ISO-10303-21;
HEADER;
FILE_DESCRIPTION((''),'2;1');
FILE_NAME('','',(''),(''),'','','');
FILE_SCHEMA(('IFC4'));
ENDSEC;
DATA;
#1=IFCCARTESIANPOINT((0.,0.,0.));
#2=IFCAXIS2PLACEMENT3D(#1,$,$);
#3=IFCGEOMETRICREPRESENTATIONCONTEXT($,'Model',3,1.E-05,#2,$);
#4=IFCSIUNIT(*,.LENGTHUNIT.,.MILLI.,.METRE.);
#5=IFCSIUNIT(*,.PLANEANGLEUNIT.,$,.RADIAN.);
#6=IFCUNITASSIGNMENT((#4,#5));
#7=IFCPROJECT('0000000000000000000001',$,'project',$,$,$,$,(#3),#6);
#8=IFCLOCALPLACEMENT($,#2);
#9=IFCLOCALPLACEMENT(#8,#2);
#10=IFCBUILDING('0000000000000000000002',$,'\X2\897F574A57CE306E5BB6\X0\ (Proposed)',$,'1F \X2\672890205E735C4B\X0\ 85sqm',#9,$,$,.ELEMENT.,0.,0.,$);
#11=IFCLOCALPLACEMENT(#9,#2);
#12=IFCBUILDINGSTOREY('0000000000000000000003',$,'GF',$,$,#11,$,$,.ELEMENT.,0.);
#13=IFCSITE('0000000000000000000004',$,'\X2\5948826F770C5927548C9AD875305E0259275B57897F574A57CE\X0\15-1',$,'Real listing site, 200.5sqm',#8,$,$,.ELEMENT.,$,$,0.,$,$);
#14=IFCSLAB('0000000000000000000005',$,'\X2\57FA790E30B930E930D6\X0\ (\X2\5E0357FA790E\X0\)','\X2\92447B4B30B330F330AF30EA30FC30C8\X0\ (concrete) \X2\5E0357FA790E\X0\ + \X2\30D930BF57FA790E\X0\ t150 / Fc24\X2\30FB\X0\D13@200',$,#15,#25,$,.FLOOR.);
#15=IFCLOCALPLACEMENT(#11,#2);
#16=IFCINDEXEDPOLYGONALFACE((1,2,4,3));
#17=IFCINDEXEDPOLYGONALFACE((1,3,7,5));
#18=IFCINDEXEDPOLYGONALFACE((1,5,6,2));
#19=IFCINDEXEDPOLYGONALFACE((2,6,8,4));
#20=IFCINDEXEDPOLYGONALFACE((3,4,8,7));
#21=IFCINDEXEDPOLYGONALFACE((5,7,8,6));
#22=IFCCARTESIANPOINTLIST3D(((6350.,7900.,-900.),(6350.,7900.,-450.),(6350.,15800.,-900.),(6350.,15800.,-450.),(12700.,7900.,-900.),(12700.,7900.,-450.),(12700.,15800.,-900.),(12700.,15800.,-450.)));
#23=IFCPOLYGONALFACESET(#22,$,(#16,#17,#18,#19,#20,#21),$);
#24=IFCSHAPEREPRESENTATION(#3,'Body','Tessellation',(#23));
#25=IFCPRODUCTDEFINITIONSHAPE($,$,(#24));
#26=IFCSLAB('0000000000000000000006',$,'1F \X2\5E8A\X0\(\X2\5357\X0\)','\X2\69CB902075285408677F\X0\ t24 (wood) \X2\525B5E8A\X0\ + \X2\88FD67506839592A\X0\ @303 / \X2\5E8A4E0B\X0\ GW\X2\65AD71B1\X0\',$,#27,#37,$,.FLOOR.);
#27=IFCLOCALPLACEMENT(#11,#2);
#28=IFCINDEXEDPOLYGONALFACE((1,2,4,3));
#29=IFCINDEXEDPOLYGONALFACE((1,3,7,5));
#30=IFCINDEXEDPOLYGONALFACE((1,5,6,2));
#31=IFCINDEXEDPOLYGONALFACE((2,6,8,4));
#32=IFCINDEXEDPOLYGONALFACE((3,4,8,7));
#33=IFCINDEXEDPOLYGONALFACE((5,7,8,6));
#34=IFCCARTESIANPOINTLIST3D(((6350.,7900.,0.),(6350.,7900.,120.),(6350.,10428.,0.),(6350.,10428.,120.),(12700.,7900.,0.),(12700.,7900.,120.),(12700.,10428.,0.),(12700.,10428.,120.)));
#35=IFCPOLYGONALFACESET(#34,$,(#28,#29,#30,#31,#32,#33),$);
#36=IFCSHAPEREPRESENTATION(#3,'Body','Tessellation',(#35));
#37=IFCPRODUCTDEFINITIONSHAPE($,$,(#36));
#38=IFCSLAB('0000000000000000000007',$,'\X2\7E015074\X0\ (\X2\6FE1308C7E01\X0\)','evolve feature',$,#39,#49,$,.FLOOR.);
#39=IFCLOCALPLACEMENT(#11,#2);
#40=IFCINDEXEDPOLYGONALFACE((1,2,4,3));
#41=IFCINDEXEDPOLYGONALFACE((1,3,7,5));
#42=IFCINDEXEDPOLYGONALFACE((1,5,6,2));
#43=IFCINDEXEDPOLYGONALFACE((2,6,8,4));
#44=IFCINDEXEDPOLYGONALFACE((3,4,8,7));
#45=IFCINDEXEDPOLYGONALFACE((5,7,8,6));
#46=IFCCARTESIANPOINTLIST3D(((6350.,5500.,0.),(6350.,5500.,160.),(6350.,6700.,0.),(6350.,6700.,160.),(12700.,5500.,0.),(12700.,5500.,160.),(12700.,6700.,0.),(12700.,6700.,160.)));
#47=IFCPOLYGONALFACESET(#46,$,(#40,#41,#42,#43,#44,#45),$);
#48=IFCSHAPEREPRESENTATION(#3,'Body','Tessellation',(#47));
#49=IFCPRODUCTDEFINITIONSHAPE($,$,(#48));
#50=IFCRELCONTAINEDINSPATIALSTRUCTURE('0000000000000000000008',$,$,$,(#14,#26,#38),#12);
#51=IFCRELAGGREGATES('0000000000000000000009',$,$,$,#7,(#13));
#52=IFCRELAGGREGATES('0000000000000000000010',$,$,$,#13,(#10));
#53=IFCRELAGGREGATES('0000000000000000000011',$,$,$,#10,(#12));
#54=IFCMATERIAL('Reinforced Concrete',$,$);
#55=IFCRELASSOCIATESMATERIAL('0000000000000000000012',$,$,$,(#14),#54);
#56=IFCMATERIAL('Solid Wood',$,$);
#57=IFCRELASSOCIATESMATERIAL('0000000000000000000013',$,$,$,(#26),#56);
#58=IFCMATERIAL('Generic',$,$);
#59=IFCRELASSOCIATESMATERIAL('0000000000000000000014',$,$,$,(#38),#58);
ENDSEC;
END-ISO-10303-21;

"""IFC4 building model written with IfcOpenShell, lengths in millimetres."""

from ifc_helpers import new_model, si_unit, frame, frame_2d, origin, place, context, project, spatial, rectangle, extrude, material, element, save


model = new_model("IFC4")

# Units and contexts
model_context = context("Model", 3, precision=1e-05, world=origin())
ifc_project = project(units=[si_unit("LENGTHUNIT", "METRE", prefix="MILLI"), si_unit("PLANEANGLEUNIT", "RADIAN")], contexts=[model_context])

# Site, building, storey
site_placement = place(None, origin())
site = spatial("IfcSite", under=ifc_project, at=site_placement, Name="奈良県大和高田市大字西坊城15-1", ObjectType="Real listing site, 200.5sqm", CompositionType="ELEMENT", RefElevation=0.0)
building_placement = place(site_placement, origin())
building = spatial("IfcBuilding", under=site, at=building_placement, Name="西坊城の家 (Proposed)", ObjectType="1F 木造平屋 85sqm", CompositionType="ELEMENT", ElevationOfRefHeight=0.0, ElevationOfTerrain=0.0)
storey_placement = place(building_placement, origin())
storey = spatial("IfcBuildingStorey", under=building, at=storey_placement, Name="GF", CompositionType="ELEMENT", Elevation=0.0)

# Slabs
ifc_material_1 = material(Name="Reinforced Concrete")
slab_1_placement = place(storey_placement, frame((3175.0, 3950.0, -450.0)))
element("IfcSlab", 1, at=slab_1_placement, inside=storey, material=ifc_material_1, Name="基礎スラブ (布基礎)", Description="鉄筋コンクリート (concrete) 布基礎 + ベタ基礎 t150 / Fc24・D13@200", PredefinedType="FLOOR", context=model_context, shape_type="SweptSolid", body=[
    extrude(rectangle(XDim=6350.0, YDim=7900.0, at=frame_2d((3175.0, 3950.0))), frame((3175.0, 3950.0, -450.0)), (0.0, 0.0, 1.0), 450.0),
])
ifc_material_2 = material(Name="Solid Wood")
slab_2_placement = place(storey_placement, frame((3175.0, 3950.0, 0.0)))
element("IfcSlab", 2, at=slab_2_placement, inside=storey, material=ifc_material_2, Name="1F 床(南)", Description="構造用合板 t24 (wood) 剛床 + 製材根太 @303 / 床下 GW断熱", PredefinedType="FLOOR", context=model_context, shape_type="SweptSolid", body=[
    extrude(rectangle(XDim=6350.0, YDim=2528.0, at=frame_2d((3175.0, 1264.0))), frame((3175.0, 3950.0, 0.0)), (0.0, 0.0, 1.0), 120.0),
])
ifc_material_3 = material(Name="Generic")
slab_3_placement = place(storey_placement, frame((3175.0, 2750.0, 0.0)))
element("IfcSlab", 3, at=slab_3_placement, inside=storey, material=ifc_material_3, Name="縁側 (濡れ縁)", Description="evolve feature", PredefinedType="FLOOR", context=model_context, shape_type="SweptSolid", body=[
    extrude(rectangle(XDim=6350.0, YDim=1200.0, at=frame_2d((3175.0, 600.0))), frame((3175.0, 2750.0, 0.0)), (0.0, 0.0, 1.0), 160.0),
])

save(model, "model.ifc")
